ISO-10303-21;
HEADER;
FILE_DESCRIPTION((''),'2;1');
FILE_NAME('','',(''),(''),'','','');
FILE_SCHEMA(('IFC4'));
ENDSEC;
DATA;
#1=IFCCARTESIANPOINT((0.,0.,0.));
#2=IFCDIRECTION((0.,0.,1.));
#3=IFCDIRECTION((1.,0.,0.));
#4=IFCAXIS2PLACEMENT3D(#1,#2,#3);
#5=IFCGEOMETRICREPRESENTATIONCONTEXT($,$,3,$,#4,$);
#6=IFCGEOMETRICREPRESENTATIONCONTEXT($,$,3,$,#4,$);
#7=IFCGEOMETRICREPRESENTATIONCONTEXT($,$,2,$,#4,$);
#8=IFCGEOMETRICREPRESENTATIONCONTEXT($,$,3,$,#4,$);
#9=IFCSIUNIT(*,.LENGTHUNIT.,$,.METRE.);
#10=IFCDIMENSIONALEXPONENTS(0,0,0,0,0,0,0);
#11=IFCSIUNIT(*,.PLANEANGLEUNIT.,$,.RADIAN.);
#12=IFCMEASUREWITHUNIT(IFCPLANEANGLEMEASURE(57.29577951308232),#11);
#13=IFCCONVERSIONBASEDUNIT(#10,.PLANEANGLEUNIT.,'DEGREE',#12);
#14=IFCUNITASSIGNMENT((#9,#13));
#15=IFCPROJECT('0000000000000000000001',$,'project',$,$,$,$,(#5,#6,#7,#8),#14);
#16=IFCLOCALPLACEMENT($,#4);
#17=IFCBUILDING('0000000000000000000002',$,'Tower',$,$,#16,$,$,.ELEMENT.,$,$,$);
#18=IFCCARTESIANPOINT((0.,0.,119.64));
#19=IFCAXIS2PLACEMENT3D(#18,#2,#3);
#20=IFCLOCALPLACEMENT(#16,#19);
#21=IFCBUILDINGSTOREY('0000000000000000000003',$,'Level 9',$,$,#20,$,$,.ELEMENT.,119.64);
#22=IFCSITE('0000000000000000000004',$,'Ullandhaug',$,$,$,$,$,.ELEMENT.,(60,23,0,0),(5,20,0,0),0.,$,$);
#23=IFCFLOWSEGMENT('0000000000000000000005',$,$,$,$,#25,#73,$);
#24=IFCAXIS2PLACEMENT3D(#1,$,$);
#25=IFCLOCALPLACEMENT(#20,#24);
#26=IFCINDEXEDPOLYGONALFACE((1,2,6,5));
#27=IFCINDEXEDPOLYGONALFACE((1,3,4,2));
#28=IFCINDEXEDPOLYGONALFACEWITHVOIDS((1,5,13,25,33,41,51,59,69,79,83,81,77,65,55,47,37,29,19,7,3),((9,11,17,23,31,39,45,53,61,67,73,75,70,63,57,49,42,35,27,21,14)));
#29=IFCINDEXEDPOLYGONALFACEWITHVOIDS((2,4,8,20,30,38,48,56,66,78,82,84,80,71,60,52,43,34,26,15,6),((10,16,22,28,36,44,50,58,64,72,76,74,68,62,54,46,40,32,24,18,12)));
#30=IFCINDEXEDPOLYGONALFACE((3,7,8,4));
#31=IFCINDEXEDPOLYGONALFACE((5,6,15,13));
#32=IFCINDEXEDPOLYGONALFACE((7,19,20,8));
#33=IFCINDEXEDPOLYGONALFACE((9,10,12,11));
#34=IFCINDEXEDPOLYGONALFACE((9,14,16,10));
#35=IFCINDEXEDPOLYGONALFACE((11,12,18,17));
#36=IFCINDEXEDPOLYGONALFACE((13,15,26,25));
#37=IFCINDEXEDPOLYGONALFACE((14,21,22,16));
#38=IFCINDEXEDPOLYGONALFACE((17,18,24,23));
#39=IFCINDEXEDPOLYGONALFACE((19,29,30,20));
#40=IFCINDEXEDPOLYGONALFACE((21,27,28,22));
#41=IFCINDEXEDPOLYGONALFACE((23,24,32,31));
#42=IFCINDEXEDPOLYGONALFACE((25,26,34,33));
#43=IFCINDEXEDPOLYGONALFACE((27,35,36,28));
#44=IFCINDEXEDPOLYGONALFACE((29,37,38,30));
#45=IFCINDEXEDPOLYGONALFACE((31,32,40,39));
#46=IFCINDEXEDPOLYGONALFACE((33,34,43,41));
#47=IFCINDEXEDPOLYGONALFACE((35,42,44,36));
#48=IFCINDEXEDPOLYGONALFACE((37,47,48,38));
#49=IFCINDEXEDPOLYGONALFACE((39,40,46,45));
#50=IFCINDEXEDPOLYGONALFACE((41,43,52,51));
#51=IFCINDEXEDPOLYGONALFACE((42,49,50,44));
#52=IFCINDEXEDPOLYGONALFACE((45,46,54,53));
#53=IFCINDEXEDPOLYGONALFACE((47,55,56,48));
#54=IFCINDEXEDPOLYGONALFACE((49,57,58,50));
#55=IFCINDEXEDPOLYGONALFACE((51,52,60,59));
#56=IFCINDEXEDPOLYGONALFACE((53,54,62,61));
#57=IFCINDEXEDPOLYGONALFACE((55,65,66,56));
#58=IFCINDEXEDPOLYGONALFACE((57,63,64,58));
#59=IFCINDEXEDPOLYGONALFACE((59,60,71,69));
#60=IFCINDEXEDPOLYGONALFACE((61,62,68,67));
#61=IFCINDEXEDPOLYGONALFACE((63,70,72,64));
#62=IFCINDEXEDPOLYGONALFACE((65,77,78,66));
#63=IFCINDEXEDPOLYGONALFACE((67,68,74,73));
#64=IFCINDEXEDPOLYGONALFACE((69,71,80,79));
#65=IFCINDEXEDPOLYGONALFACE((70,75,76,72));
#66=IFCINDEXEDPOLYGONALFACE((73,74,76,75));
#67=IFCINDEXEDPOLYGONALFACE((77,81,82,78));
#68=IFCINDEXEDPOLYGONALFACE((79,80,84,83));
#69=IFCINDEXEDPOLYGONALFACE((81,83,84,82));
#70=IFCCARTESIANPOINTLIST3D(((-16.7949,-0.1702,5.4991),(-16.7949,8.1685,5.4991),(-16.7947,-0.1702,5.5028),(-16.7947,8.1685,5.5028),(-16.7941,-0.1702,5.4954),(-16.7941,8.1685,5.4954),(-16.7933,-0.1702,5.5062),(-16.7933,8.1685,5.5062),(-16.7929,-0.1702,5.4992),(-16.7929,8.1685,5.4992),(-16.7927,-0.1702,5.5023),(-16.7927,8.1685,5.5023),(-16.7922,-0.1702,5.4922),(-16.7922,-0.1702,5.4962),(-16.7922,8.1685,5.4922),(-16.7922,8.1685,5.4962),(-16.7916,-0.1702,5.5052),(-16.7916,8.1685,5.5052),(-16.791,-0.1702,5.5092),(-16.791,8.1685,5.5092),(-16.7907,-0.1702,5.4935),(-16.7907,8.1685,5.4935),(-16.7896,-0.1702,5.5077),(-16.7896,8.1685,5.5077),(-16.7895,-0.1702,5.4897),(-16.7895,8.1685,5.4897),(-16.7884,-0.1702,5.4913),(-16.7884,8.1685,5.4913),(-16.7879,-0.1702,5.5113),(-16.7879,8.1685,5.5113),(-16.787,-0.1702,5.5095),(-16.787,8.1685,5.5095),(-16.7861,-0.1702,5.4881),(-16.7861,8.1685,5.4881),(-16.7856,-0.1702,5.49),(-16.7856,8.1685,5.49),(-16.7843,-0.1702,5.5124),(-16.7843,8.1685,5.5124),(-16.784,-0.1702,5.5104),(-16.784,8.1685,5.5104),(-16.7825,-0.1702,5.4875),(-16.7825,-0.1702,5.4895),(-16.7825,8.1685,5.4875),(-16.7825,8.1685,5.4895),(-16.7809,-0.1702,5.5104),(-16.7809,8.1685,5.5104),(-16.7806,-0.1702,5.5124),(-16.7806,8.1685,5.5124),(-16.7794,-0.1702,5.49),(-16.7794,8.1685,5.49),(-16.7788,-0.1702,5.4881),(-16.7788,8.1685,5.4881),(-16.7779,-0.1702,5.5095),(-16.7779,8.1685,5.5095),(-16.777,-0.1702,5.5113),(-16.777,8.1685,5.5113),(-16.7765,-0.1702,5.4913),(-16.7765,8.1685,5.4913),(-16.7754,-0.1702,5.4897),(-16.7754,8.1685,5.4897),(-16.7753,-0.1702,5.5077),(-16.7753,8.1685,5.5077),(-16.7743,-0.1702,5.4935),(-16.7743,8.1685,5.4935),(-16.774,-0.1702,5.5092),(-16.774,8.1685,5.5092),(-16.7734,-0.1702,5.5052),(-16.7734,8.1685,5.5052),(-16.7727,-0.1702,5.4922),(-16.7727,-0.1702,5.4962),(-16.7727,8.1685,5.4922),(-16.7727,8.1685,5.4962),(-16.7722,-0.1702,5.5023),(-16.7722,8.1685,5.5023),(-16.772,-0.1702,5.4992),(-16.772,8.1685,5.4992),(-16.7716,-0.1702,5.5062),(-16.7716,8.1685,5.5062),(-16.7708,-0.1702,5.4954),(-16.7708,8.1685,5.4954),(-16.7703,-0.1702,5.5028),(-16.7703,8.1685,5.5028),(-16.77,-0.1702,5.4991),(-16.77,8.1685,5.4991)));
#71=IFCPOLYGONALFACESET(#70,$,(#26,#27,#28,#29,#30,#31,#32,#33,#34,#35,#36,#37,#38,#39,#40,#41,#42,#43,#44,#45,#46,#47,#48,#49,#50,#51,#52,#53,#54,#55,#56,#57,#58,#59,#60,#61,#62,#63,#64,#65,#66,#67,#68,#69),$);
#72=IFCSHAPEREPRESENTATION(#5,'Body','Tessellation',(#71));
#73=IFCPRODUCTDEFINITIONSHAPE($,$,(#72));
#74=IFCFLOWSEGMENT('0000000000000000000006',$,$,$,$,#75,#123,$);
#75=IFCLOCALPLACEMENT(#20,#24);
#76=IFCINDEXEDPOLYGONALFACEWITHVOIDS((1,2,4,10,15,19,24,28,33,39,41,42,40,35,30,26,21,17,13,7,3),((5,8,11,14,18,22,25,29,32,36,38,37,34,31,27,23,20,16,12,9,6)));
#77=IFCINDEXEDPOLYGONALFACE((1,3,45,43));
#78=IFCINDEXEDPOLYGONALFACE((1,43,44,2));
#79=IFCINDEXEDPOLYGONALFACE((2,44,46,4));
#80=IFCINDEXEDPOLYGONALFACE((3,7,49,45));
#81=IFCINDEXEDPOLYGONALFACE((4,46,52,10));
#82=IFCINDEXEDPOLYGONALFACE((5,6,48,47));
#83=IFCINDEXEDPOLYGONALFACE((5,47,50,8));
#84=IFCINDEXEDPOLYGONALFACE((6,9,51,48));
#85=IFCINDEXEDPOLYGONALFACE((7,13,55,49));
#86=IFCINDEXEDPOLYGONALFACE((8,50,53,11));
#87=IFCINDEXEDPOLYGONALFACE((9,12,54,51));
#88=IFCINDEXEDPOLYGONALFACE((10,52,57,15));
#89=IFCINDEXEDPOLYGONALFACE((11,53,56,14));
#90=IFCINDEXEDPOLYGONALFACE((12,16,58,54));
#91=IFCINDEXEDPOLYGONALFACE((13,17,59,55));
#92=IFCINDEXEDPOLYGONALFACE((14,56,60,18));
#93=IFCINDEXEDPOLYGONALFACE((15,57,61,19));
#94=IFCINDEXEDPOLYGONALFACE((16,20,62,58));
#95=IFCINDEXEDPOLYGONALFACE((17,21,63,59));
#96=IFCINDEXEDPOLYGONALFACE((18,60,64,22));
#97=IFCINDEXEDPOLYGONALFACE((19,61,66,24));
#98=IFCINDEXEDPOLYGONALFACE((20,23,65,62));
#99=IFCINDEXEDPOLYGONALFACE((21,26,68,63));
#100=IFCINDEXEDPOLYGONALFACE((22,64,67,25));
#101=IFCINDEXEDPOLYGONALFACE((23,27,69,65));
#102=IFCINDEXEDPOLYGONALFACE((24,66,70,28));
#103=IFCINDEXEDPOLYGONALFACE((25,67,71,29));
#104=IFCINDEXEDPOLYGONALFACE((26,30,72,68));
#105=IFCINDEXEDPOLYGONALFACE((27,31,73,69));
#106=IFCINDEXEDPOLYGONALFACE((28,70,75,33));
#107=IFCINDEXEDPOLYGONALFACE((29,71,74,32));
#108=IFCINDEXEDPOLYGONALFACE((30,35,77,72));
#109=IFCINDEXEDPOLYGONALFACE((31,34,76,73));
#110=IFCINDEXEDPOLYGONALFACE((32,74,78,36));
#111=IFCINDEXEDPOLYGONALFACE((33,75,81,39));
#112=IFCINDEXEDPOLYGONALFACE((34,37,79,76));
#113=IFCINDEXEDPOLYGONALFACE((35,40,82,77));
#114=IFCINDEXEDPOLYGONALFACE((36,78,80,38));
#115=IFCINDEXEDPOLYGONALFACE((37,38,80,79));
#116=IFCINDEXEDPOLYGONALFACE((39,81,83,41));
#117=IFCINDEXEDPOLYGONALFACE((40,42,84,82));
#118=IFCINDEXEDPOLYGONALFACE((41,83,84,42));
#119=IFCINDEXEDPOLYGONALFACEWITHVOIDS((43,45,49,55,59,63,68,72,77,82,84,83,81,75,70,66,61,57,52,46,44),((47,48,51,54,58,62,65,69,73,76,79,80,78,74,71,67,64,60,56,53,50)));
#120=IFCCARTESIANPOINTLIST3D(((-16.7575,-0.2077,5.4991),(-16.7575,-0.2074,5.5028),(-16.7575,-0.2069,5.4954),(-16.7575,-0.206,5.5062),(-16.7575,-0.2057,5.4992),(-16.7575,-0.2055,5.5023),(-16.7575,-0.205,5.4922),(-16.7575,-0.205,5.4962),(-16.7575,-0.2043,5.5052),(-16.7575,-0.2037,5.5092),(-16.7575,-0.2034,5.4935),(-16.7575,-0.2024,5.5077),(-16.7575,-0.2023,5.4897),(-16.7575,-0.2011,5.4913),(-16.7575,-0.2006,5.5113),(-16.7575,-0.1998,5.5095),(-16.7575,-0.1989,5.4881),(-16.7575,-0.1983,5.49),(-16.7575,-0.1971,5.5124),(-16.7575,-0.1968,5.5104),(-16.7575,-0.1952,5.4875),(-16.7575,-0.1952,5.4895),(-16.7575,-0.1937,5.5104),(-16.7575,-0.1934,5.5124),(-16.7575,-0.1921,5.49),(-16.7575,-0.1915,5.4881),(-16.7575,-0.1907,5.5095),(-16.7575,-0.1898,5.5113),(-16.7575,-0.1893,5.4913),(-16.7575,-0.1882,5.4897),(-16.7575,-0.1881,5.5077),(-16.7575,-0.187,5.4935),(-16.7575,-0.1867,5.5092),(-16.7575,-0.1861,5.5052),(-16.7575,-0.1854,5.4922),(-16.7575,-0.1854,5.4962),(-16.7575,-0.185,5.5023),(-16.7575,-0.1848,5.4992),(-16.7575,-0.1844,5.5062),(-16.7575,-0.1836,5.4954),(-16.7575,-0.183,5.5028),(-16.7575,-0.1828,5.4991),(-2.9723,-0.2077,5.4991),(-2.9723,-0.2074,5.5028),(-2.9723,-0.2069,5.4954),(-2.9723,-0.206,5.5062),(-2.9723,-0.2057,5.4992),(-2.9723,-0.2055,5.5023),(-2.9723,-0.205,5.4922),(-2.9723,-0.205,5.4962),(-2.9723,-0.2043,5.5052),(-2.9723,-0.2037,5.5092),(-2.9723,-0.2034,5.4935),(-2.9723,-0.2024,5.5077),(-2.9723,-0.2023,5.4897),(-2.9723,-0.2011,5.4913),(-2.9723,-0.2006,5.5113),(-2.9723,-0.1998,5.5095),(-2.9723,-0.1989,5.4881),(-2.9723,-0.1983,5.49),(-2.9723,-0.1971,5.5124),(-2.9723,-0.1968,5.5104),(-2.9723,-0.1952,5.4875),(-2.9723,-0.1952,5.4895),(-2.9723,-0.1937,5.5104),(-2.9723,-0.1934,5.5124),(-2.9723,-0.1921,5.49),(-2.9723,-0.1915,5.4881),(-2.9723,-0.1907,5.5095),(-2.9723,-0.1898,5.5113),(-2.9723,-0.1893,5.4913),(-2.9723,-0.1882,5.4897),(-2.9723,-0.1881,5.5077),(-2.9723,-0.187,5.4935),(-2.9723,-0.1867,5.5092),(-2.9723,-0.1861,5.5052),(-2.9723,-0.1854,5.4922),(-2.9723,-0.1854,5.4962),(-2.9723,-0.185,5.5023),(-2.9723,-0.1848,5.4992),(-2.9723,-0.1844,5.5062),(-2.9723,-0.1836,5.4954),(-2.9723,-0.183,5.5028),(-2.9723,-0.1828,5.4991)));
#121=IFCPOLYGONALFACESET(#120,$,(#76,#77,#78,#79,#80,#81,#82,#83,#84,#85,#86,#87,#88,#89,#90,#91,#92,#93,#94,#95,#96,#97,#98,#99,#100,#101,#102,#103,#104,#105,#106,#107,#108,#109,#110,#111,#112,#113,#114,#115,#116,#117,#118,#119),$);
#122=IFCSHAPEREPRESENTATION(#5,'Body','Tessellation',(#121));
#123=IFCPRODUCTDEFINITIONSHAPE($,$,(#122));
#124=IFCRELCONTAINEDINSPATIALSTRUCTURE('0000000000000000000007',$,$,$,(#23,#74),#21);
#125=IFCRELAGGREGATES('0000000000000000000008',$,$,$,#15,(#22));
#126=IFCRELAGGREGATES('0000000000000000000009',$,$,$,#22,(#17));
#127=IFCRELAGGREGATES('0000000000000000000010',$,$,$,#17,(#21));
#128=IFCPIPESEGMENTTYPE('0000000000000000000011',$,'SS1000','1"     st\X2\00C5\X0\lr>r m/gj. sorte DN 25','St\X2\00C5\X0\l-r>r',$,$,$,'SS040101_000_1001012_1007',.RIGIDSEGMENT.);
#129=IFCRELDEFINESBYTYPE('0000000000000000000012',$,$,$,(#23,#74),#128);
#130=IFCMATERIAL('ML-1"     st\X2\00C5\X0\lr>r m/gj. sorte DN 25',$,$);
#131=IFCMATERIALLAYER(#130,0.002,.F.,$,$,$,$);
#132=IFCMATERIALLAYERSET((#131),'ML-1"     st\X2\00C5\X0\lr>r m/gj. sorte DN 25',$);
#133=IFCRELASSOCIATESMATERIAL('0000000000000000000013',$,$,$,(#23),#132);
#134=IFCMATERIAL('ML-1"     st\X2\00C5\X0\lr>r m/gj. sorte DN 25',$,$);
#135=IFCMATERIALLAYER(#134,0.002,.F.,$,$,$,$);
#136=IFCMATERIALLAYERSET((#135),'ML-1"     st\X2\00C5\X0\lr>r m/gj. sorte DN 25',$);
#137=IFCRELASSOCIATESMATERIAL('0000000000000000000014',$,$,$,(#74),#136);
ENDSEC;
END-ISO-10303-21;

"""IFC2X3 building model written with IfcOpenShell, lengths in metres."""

from ifc_helpers import new_model, entity, si_unit, converted_unit, frame, origin_with_axes, origin_2d_with_axis, place, context, project, spatial, hollow_circle, extrude, material, layer, layer_set, layer_usage, type_object, element, save


model = new_model("IFC2X3")

# Units and contexts
context_of_model_1 = context(None, 3, world=origin_with_axes())
context_of_model_2 = context(None, 3, world=origin_with_axes())
context_of_model_3 = context(None, 2, world=origin_with_axes())
context_of_model_4 = context(None, 3, world=origin_with_axes())
ifc_project = project(units=[si_unit("LENGTHUNIT", "METRE"), converted_unit("PLANEANGLEUNIT", "DEGREE", entity("IfcPlaneAngleMeasure", 57.29577951308232), si_unit("PLANEANGLEUNIT", "RADIAN"), dimensions=[0, 0, 0, 0, 0, 0, 0])], contexts=[context_of_model_1, context_of_model_2, context_of_model_3, context_of_model_4])

# Site, building, storey
site = spatial("IfcSite", under=ifc_project, Name="Ullandhaug", CompositionType="ELEMENT", RefLatitude=(60, 23, 0, 0), RefLongitude=(5, 20, 0, 0), RefElevation=0.0)
building_placement = place(None, origin_with_axes())
building = spatial("IfcBuilding", under=site, at=building_placement, Name="Tower", CompositionType="ELEMENT")
storey_placement = place(building_placement, frame((0.0, 0.0, 119.64), z_axis=(0.0, 0.0, 1.0), x_axis=(1.0, 0.0, 0.0)))
storey = spatial("IfcBuildingStorey", under=building, at=storey_placement, Name="Level 9", CompositionType="ELEMENT", Elevation=119.64)

# Flow segments
ifc_material_1 = material(Name="ML-1\"     stÅlr>r m/gj. sorte DN 25")
ifc_layer_1 = layer(ifc_material_1, 0.002, ventilated=False)
ifc_layer_set_1 = layer_set([ifc_layer_1], Name="ML-1\"     stÅlr>r m/gj. sorte DN 25")
ifc_layer_usage_1 = layer_usage(ifc_layer_set_1, "AXIS2", "POSITIVE", 0.0)
pipe_segment_type_1 = type_object("IfcPipeSegmentType", Name="SS1000", Description="1\"     stÅlr>r m/gj. sorte DN 25", ApplicableOccurrence="StÅl-r>r", ElementType="SS040101_000_1001012_1007", PredefinedType="RIGIDSEGMENT")
flow_segment_1_placement = place(storey_placement, frame((-16.7825, 8.1685, 5.5), z_axis=(0.0, -1.0, 0.0), x_axis=(0.0, 0.0, -1.0)))
element("IfcFlowSegment", 1, at=flow_segment_1_placement, inside=storey, type_object=pipe_segment_type_1, material=ifc_layer_usage_1, context=context_of_model_1, shape_type="SweptSolid", body=[
    extrude(hollow_circle(Radius=0.0125, WallThickness=0.002, at=origin_2d_with_axis()), origin_with_axes(), (0.0, 0.0, 1.0), 8.3387),
])
ifc_material_2 = material(Name="ML-1\"     stÅlr>r m/gj. sorte DN 25")
ifc_layer_2 = layer(ifc_material_2, 0.002, ventilated=False)
ifc_layer_set_2 = layer_set([ifc_layer_2], Name="ML-1\"     stÅlr>r m/gj. sorte DN 25")
ifc_layer_usage_2 = layer_usage(ifc_layer_set_2, "AXIS2", "POSITIVE", 0.0)
flow_segment_2_placement = place(storey_placement, frame((-16.7575, -0.1952, 5.5), z_axis=(1.0, 0.0, 0.0), x_axis=(0.0, 0.0, -1.0)))
element("IfcFlowSegment", 2, at=flow_segment_2_placement, inside=storey, type_object=pipe_segment_type_1, material=ifc_layer_usage_2, context=context_of_model_1, shape_type="SweptSolid", body=[
    extrude(hollow_circle(Radius=0.0125, WallThickness=0.002, at=origin_2d_with_axis()), origin_with_axes(), (0.0, 0.0, 1.0), 13.7851),
])

save(model, "model.ifc")
